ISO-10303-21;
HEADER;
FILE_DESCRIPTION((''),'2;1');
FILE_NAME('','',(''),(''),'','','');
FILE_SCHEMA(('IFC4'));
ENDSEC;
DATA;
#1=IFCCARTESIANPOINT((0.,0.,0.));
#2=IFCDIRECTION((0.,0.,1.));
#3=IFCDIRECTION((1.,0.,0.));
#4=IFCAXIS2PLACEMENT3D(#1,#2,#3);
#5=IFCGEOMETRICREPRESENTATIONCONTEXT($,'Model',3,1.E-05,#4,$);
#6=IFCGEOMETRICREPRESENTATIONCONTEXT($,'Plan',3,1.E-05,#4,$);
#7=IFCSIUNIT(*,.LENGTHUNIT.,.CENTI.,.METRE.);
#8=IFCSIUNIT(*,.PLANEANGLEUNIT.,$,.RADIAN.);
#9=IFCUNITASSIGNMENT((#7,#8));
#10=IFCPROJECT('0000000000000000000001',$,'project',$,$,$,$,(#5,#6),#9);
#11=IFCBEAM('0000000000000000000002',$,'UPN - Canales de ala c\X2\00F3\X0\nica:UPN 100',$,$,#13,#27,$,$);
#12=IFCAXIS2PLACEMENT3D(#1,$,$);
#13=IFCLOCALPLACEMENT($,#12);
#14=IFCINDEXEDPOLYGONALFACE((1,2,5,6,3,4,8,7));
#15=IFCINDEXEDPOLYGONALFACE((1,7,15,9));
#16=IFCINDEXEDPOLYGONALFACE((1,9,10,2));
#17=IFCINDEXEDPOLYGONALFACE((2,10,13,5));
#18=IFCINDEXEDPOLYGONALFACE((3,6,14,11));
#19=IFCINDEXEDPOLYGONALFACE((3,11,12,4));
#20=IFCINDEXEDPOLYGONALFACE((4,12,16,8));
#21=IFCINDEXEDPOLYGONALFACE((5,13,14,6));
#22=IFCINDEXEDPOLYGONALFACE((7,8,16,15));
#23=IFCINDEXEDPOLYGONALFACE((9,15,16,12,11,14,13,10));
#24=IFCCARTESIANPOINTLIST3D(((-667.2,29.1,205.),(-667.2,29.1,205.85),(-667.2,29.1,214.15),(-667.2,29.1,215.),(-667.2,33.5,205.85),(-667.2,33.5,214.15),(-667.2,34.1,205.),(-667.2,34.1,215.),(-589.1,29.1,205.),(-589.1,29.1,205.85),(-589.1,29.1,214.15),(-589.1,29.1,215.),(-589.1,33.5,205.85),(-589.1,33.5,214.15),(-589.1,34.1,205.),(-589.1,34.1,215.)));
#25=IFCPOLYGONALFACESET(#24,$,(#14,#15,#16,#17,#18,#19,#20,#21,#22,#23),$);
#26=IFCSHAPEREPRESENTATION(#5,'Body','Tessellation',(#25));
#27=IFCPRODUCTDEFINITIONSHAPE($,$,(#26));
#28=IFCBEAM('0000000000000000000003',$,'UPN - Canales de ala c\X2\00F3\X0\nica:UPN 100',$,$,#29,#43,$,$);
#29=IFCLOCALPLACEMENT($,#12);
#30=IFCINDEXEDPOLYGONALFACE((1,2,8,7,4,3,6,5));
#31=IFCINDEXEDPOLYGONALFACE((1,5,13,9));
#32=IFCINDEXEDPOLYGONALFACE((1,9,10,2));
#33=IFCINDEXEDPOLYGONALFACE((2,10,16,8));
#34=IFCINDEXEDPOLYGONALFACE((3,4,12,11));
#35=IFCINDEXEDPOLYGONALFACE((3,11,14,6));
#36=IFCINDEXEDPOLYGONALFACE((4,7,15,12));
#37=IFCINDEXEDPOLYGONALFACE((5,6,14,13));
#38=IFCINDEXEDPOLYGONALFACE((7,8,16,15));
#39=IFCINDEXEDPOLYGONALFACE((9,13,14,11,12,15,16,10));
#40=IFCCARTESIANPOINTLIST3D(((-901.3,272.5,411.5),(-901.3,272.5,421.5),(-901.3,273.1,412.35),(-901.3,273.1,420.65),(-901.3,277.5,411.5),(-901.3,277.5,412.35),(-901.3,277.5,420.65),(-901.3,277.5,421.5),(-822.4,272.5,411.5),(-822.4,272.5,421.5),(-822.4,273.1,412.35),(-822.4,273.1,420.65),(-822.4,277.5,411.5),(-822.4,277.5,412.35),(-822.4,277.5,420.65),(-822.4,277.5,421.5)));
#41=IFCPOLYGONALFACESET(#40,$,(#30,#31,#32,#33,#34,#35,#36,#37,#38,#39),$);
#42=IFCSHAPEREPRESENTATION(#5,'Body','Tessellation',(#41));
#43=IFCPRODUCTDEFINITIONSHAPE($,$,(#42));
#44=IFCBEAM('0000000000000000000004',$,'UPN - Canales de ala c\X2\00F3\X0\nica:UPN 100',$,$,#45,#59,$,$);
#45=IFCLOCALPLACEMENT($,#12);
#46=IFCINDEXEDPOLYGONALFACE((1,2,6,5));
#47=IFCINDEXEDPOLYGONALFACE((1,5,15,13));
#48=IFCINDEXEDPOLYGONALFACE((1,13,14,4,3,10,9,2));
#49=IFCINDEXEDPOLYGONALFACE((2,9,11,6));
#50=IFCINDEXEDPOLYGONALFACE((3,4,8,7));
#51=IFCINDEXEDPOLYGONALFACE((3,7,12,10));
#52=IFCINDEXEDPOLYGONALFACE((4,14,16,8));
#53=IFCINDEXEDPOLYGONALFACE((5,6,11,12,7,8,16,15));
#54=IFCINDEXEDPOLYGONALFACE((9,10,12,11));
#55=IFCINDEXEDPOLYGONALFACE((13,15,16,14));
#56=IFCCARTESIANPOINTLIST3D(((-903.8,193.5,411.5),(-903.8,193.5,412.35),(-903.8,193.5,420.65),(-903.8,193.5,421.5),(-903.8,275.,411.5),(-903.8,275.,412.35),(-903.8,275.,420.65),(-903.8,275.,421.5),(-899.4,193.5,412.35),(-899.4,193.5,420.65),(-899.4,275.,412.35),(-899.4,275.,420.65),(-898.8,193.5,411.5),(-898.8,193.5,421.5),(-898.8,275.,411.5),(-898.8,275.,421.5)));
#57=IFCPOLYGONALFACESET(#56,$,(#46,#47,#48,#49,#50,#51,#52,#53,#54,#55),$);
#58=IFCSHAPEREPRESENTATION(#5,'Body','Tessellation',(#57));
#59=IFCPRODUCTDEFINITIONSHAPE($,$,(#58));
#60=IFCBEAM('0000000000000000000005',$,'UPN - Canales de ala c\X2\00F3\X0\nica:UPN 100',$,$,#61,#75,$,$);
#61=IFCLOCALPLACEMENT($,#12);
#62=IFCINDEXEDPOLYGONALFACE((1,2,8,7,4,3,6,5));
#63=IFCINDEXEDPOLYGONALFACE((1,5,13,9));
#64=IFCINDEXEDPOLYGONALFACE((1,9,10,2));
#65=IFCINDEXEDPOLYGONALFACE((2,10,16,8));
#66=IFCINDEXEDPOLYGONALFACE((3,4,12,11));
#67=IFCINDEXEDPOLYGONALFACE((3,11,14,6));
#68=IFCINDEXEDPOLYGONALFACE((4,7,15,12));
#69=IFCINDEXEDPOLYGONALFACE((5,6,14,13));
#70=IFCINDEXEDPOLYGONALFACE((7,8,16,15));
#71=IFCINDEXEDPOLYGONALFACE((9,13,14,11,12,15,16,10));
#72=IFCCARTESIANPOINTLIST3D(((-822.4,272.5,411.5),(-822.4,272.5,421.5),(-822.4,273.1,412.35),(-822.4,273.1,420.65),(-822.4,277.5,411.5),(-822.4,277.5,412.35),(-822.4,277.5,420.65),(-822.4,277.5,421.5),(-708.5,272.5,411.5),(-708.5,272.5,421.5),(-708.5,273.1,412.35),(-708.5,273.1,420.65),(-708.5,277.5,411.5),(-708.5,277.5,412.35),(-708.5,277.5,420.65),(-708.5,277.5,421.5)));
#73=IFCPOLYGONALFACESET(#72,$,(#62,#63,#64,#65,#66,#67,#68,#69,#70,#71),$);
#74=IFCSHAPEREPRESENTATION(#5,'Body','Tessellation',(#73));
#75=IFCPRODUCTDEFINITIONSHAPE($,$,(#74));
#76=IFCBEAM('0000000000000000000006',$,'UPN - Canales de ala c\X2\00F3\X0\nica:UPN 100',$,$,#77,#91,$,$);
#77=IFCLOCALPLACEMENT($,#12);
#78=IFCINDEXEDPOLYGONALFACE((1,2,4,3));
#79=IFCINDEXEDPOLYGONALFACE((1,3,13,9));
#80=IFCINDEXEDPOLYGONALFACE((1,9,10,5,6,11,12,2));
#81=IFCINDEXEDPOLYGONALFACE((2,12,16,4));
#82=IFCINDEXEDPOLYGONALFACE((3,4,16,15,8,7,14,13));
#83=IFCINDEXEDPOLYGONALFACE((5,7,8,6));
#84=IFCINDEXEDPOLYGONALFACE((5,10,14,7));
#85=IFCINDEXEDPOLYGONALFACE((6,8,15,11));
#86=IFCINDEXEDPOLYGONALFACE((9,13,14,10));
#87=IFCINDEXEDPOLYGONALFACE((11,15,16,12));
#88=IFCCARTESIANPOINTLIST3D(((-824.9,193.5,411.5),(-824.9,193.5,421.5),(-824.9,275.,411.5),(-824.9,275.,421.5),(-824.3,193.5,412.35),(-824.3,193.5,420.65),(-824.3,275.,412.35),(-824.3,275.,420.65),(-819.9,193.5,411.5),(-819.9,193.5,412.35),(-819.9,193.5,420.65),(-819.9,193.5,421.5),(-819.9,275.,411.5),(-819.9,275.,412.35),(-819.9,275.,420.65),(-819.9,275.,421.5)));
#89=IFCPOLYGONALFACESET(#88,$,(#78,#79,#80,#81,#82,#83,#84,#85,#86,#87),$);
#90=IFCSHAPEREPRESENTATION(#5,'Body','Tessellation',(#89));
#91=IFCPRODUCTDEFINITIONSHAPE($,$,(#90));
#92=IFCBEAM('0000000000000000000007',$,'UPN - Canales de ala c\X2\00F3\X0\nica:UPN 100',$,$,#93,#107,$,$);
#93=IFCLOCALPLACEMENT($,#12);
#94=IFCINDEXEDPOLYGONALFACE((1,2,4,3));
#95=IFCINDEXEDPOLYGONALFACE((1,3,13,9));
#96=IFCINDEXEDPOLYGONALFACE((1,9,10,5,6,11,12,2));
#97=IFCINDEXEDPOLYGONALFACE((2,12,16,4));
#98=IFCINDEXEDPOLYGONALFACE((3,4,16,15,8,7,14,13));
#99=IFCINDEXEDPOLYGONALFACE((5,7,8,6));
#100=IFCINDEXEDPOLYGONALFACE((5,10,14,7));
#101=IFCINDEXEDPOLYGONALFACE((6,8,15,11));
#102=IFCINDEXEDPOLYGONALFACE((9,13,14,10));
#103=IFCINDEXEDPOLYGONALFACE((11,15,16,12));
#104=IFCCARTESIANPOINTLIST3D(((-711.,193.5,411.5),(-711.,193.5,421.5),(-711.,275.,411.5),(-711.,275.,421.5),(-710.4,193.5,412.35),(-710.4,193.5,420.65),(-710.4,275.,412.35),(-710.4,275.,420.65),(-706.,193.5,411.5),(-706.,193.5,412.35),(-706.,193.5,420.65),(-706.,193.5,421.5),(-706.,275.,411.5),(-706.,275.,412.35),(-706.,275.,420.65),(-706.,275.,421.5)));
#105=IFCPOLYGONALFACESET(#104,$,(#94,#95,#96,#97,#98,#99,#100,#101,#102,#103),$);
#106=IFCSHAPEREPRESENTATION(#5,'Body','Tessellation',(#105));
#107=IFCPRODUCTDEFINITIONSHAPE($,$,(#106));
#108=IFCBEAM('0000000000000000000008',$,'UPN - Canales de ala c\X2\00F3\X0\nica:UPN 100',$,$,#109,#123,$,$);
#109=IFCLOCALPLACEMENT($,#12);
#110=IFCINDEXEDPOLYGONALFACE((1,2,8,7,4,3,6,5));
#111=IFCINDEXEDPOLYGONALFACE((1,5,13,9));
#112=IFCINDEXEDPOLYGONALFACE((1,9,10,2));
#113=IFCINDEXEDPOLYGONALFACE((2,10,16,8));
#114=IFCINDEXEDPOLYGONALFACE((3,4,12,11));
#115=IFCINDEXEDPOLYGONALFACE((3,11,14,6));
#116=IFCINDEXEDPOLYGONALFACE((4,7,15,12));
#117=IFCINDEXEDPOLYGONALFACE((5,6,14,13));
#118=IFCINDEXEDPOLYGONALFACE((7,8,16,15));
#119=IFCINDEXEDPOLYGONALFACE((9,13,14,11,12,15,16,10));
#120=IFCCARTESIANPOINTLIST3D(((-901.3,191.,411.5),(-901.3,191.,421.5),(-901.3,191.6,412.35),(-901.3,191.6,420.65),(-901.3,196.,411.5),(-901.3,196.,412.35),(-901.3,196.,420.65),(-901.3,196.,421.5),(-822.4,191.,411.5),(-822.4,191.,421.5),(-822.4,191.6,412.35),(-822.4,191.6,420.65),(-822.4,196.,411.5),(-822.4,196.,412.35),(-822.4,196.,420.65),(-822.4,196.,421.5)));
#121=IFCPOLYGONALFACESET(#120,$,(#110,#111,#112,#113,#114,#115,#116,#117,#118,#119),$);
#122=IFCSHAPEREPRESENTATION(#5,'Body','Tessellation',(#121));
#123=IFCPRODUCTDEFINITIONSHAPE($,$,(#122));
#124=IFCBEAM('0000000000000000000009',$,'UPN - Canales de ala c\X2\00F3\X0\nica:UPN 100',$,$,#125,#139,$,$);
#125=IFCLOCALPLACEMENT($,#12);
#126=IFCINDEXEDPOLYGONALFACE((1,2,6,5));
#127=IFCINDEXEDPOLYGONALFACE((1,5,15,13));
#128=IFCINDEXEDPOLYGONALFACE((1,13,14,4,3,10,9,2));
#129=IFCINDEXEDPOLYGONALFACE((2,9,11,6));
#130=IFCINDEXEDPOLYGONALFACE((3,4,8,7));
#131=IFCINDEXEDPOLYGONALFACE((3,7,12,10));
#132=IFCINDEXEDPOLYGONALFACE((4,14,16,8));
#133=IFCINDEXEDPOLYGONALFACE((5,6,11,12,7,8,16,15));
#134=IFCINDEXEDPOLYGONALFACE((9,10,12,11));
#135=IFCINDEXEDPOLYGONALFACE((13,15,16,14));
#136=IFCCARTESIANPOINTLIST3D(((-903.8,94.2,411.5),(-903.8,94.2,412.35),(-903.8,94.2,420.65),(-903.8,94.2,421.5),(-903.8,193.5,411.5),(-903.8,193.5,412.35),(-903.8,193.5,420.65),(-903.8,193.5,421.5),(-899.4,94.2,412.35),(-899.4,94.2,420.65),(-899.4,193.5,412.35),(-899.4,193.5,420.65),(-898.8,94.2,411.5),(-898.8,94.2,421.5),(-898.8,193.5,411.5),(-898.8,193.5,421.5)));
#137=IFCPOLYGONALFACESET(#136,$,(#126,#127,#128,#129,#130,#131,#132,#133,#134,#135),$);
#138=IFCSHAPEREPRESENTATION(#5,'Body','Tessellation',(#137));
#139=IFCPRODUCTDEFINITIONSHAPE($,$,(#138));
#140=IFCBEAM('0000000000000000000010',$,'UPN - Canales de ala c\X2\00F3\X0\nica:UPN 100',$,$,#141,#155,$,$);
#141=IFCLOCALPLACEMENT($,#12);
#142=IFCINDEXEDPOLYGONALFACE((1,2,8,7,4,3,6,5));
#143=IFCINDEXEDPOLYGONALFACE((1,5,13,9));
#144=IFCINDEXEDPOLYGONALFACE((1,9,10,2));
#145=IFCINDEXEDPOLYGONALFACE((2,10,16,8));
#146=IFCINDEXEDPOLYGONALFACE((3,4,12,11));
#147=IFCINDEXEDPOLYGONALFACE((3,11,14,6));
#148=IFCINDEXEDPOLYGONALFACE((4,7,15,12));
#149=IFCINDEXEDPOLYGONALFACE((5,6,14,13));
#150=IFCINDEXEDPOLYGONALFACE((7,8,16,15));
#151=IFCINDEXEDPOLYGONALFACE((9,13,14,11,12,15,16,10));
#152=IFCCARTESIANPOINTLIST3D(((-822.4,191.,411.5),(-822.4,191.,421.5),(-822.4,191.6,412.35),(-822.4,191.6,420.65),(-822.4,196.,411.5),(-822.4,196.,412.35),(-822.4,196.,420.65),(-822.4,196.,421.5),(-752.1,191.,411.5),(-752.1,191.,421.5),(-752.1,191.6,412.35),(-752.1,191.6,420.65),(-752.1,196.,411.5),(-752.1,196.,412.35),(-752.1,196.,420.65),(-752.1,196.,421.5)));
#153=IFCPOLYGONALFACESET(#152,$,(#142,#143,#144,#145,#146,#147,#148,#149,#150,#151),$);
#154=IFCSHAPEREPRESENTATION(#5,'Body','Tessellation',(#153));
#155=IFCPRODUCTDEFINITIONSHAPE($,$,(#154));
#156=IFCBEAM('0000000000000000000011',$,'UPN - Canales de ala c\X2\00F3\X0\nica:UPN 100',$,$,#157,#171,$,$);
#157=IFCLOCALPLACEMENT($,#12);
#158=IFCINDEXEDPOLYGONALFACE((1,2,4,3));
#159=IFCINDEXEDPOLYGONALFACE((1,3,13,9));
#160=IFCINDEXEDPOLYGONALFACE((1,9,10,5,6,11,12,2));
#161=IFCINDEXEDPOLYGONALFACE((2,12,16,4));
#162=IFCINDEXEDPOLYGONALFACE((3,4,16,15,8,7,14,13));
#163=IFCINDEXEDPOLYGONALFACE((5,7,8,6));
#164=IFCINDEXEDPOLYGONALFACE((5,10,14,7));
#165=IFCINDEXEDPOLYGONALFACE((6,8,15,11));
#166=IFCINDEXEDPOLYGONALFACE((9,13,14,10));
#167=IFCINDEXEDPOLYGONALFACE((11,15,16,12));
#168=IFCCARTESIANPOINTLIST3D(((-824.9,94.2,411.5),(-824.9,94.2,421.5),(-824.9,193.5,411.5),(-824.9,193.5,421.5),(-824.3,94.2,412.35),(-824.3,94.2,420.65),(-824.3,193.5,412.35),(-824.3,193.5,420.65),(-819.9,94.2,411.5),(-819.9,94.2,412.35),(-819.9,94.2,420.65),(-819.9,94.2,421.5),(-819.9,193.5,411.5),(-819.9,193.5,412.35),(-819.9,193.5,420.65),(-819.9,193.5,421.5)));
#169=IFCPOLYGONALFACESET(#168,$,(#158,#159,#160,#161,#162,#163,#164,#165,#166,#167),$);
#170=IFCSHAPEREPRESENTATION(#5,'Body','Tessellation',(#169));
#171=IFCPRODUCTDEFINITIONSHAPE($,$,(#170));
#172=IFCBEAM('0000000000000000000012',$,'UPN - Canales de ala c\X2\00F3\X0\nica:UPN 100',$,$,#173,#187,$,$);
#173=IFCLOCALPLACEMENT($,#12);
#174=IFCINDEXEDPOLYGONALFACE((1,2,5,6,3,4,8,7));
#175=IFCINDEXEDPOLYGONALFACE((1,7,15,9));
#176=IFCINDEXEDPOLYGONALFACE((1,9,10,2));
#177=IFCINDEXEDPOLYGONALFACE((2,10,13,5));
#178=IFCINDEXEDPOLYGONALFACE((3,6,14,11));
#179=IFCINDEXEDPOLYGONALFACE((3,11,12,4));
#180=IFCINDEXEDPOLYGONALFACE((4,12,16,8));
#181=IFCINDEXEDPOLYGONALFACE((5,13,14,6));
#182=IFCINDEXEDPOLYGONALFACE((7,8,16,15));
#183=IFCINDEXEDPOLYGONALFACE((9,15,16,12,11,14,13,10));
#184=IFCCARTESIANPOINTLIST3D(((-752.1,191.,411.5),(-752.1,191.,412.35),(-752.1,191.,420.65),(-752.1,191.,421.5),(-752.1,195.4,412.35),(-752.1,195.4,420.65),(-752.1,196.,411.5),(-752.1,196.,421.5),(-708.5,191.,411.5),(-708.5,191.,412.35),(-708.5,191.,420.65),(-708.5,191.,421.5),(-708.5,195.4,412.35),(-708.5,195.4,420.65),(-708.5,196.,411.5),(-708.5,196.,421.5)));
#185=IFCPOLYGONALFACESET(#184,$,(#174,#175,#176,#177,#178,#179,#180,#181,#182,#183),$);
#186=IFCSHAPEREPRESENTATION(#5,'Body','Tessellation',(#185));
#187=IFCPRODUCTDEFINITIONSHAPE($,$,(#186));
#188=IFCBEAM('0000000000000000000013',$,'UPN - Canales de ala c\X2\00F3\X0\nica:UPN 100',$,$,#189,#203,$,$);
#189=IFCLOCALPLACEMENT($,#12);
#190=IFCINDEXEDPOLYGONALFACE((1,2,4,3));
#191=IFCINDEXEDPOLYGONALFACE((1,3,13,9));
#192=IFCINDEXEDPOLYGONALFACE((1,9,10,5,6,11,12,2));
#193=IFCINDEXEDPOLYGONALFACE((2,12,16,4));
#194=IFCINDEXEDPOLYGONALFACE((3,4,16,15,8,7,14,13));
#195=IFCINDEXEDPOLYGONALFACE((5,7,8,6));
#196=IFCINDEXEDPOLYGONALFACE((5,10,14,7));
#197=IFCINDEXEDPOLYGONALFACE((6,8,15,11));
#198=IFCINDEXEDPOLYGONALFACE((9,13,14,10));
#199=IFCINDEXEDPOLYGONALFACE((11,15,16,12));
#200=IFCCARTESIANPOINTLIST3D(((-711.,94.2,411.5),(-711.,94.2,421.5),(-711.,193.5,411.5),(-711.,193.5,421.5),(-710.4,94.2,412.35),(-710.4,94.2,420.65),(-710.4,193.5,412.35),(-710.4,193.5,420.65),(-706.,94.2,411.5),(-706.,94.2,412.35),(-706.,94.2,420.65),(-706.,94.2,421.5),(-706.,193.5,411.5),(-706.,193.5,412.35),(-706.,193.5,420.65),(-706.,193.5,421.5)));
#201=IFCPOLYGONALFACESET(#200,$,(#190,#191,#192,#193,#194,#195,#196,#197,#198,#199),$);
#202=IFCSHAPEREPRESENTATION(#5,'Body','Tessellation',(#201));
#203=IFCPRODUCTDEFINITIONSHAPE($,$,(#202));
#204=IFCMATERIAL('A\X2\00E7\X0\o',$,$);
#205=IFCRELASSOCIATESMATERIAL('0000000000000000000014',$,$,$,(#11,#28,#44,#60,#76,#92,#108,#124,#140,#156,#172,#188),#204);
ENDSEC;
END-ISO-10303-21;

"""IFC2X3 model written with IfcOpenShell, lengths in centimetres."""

from ifc_helpers import new_model, si_unit, frame, frame_2d, origin_with_axes, origin_2d_with_axis, place, context, project, u_section, extrude, material, element, save


model = new_model("IFC2X3")

# Units and contexts
model_context = context("Model", 3, precision=1e-05, world=origin_with_axes())
plan_context = context("Plan", 3, precision=1e-05, world=origin_with_axes())
ifc_project = project(units=[si_unit("LENGTHUNIT", "METRE", prefix="CENTI"), si_unit("PLANEANGLEUNIT", "RADIAN")], contexts=[model_context, plan_context])

# Shared definitions
ifc_material = material(Name="Aço")

# Beams
beam_1_placement = place(None, frame((-589.1, 31.6, 210.0), z_axis=(-1.0, 0.0, 0.0), x_axis=(0.0, -1.0, 0.0)))
element("IfcBeam", 1, at=beam_1_placement, material=ifc_material, Name="UPN - Canales de ala cónica:UPN 100", context=model_context, shape_type="SweptSolid", body=[
    extrude(u_section(Depth=10.0, FlangeWidth=5.0, WebThickness=0.6, FlangeThickness=0.85, FilletRadius=0.0, EdgeRadius=0.0, FlangeSlope=0.0, CentreOfGravityInX=0.0, at=frame_2d((0.0, 0.0), x_axis=(1.0, 0.0))), origin_with_axes(), (0.0, 0.0, 1.0), 78.1),
])
beam_2_placement = place(None, frame((-822.4, 275.0, 416.5), z_axis=(-1.0, 0.0, 0.0), x_axis=(0.0, 1.0, 0.0)))
element("IfcBeam", 2, at=beam_2_placement, material=ifc_material, Name="UPN - Canales de ala cónica:UPN 100", context=model_context, shape_type="SweptSolid", body=[
    extrude(u_section(Depth=10.0, FlangeWidth=5.0, WebThickness=0.6, FlangeThickness=0.85, FilletRadius=0.0, EdgeRadius=0.0, FlangeSlope=0.0, CentreOfGravityInX=0.0, at=origin_2d_with_axis()), origin_with_axes(), (0.0, 0.0, 1.0), 78.9),
])
beam_3_placement = place(None, frame((-901.3, 193.5, 416.5), z_axis=(0.0, 1.0, 0.0), x_axis=(-1.0, 0.0, 0.0)))
element("IfcBeam", 3, at=beam_3_placement, material=ifc_material, Name="UPN - Canales de ala cónica:UPN 100", context=model_context, shape_type="SweptSolid", body=[
    extrude(u_section(Depth=10.0, FlangeWidth=5.0, WebThickness=0.6, FlangeThickness=0.85, FilletRadius=0.0, EdgeRadius=0.0, FlangeSlope=0.0, CentreOfGravityInX=0.0, at=origin_2d_with_axis()), origin_with_axes(), (0.0, 0.0, 1.0), 81.5),
])
beam_4_placement = place(None, frame((-708.5, 275.0, 416.5), z_axis=(-1.0, 0.0, 0.0), x_axis=(0.0, 1.0, 0.0)))
element("IfcBeam", 4, at=beam_4_placement, material=ifc_material, Name="UPN - Canales de ala cónica:UPN 100", context=model_context, shape_type="SweptSolid", body=[
    extrude(u_section(Depth=10.0, FlangeWidth=5.0, WebThickness=0.6, FlangeThickness=0.85, FilletRadius=0.0, EdgeRadius=0.0, FlangeSlope=0.0, CentreOfGravityInX=0.0, at=origin_2d_with_axis()), origin_with_axes(), (0.0, 0.0, 1.0), 113.9),
])
for number, where, z_axis, x_axis, name in (
    (5, (-822.4, 193.5, 416.5), (0.0, 1.0, 0.0), (1.0, 0.0, 0.0), "UPN - Canales de ala cónica:UPN 100"),
    (6, (-708.5, 193.5, 416.5), (0.0, 1.0, 0.0), (1.0, 0.0, 0.0), "UPN - Canales de ala cónica:UPN 100"),
):
    element("IfcBeam", number, at=place(None, frame(where, z_axis=z_axis, x_axis=x_axis)), material=ifc_material, Name=name, context=model_context, shape_type="SweptSolid", body=[
        extrude(u_section(Depth=10.0, FlangeWidth=5.0, WebThickness=0.6, FlangeThickness=0.85, FilletRadius=0.0, EdgeRadius=0.0, FlangeSlope=0.0, CentreOfGravityInX=0.0, at=origin_2d_with_axis()), origin_with_axes(), (0.0, 0.0, 1.0), 81.5),
    ])
beam_5_placement = place(None, frame((-822.4, 193.5, 416.5), z_axis=(-1.0, 0.0, 0.0), x_axis=(0.0, 1.0, 0.0)))
element("IfcBeam", 7, at=beam_5_placement, material=ifc_material, Name="UPN - Canales de ala cónica:UPN 100", context=model_context, shape_type="SweptSolid", body=[
    extrude(u_section(Depth=10.0, FlangeWidth=5.0, WebThickness=0.6, FlangeThickness=0.85, FilletRadius=0.0, EdgeRadius=0.0, FlangeSlope=0.0, CentreOfGravityInX=0.0, at=origin_2d_with_axis()), origin_with_axes(), (0.0, 0.0, 1.0), 78.9),
])
beam_6_placement = place(None, frame((-901.3, 94.2, 416.5), z_axis=(0.0, 1.0, 0.0), x_axis=(-1.0, 0.0, 0.0)))
element("IfcBeam", 8, at=beam_6_placement, material=ifc_material, Name="UPN - Canales de ala cónica:UPN 100", context=model_context, shape_type="SweptSolid", body=[
    extrude(u_section(Depth=10.0, FlangeWidth=5.0, WebThickness=0.6, FlangeThickness=0.85, FilletRadius=0.0, EdgeRadius=0.0, FlangeSlope=0.0, CentreOfGravityInX=0.0, at=origin_2d_with_axis()), origin_with_axes(), (0.0, 0.0, 1.0), 99.3),
])
beam_7_placement = place(None, frame((-752.1, 193.5, 416.5), z_axis=(-1.0, 0.0, 0.0), x_axis=(0.0, 1.0, 0.0)))
element("IfcBeam", 9, at=beam_7_placement, material=ifc_material, Name="UPN - Canales de ala cónica:UPN 100", context=model_context, shape_type="SweptSolid", body=[
    extrude(u_section(Depth=10.0, FlangeWidth=5.0, WebThickness=0.6, FlangeThickness=0.85, FilletRadius=0.0, EdgeRadius=0.0, FlangeSlope=0.0, CentreOfGravityInX=0.0, at=origin_2d_with_axis()), origin_with_axes(), (0.0, 0.0, 1.0), 70.3),
])
beam_8_placement = place(None, frame((-822.4, 94.2, 416.5), z_axis=(0.0, 1.0, 0.0), x_axis=(1.0, 0.0, 0.0)))
element("IfcBeam", 10, at=beam_8_placement, material=ifc_material, Name="UPN - Canales de ala cónica:UPN 100", context=model_context, shape_type="SweptSolid", body=[
    extrude(u_section(Depth=10.0, FlangeWidth=5.0, WebThickness=0.6, FlangeThickness=0.85, FilletRadius=0.0, EdgeRadius=0.0, FlangeSlope=0.0, CentreOfGravityInX=0.0, at=origin_2d_with_axis()), origin_with_axes(), (0.0, 0.0, 1.0), 99.3),
])
beam_9_placement = place(None, frame((-708.5, 193.5, 416.5), z_axis=(-1.0, 0.0, 0.0), x_axis=(0.0, -1.0, 0.0)))
element("IfcBeam", 11, at=beam_9_placement, material=ifc_material, Name="UPN - Canales de ala cónica:UPN 100", context=model_context, shape_type="SweptSolid", body=[
    extrude(u_section(Depth=10.0, FlangeWidth=5.0, WebThickness=0.6, FlangeThickness=0.85, FilletRadius=0.0, EdgeRadius=0.0, FlangeSlope=0.0, CentreOfGravityInX=0.0, at=origin_2d_with_axis()), origin_with_axes(), (0.0, 0.0, 1.0), 43.6),
])
beam_10_placement = place(None, frame((-708.5, 94.2, 416.5), z_axis=(0.0, 1.0, 0.0), x_axis=(1.0, 0.0, 0.0)))
element("IfcBeam", 12, at=beam_10_placement, material=ifc_material, Name="UPN - Canales de ala cónica:UPN 100", context=model_context, shape_type="SweptSolid", body=[
    extrude(u_section(Depth=10.0, FlangeWidth=5.0, WebThickness=0.6, FlangeThickness=0.85, FilletRadius=0.0, EdgeRadius=0.0, FlangeSlope=0.0, CentreOfGravityInX=0.0, at=origin_2d_with_axis()), origin_with_axes(), (0.0, 0.0, 1.0), 99.3),
])

save(model, "model.ifc")
